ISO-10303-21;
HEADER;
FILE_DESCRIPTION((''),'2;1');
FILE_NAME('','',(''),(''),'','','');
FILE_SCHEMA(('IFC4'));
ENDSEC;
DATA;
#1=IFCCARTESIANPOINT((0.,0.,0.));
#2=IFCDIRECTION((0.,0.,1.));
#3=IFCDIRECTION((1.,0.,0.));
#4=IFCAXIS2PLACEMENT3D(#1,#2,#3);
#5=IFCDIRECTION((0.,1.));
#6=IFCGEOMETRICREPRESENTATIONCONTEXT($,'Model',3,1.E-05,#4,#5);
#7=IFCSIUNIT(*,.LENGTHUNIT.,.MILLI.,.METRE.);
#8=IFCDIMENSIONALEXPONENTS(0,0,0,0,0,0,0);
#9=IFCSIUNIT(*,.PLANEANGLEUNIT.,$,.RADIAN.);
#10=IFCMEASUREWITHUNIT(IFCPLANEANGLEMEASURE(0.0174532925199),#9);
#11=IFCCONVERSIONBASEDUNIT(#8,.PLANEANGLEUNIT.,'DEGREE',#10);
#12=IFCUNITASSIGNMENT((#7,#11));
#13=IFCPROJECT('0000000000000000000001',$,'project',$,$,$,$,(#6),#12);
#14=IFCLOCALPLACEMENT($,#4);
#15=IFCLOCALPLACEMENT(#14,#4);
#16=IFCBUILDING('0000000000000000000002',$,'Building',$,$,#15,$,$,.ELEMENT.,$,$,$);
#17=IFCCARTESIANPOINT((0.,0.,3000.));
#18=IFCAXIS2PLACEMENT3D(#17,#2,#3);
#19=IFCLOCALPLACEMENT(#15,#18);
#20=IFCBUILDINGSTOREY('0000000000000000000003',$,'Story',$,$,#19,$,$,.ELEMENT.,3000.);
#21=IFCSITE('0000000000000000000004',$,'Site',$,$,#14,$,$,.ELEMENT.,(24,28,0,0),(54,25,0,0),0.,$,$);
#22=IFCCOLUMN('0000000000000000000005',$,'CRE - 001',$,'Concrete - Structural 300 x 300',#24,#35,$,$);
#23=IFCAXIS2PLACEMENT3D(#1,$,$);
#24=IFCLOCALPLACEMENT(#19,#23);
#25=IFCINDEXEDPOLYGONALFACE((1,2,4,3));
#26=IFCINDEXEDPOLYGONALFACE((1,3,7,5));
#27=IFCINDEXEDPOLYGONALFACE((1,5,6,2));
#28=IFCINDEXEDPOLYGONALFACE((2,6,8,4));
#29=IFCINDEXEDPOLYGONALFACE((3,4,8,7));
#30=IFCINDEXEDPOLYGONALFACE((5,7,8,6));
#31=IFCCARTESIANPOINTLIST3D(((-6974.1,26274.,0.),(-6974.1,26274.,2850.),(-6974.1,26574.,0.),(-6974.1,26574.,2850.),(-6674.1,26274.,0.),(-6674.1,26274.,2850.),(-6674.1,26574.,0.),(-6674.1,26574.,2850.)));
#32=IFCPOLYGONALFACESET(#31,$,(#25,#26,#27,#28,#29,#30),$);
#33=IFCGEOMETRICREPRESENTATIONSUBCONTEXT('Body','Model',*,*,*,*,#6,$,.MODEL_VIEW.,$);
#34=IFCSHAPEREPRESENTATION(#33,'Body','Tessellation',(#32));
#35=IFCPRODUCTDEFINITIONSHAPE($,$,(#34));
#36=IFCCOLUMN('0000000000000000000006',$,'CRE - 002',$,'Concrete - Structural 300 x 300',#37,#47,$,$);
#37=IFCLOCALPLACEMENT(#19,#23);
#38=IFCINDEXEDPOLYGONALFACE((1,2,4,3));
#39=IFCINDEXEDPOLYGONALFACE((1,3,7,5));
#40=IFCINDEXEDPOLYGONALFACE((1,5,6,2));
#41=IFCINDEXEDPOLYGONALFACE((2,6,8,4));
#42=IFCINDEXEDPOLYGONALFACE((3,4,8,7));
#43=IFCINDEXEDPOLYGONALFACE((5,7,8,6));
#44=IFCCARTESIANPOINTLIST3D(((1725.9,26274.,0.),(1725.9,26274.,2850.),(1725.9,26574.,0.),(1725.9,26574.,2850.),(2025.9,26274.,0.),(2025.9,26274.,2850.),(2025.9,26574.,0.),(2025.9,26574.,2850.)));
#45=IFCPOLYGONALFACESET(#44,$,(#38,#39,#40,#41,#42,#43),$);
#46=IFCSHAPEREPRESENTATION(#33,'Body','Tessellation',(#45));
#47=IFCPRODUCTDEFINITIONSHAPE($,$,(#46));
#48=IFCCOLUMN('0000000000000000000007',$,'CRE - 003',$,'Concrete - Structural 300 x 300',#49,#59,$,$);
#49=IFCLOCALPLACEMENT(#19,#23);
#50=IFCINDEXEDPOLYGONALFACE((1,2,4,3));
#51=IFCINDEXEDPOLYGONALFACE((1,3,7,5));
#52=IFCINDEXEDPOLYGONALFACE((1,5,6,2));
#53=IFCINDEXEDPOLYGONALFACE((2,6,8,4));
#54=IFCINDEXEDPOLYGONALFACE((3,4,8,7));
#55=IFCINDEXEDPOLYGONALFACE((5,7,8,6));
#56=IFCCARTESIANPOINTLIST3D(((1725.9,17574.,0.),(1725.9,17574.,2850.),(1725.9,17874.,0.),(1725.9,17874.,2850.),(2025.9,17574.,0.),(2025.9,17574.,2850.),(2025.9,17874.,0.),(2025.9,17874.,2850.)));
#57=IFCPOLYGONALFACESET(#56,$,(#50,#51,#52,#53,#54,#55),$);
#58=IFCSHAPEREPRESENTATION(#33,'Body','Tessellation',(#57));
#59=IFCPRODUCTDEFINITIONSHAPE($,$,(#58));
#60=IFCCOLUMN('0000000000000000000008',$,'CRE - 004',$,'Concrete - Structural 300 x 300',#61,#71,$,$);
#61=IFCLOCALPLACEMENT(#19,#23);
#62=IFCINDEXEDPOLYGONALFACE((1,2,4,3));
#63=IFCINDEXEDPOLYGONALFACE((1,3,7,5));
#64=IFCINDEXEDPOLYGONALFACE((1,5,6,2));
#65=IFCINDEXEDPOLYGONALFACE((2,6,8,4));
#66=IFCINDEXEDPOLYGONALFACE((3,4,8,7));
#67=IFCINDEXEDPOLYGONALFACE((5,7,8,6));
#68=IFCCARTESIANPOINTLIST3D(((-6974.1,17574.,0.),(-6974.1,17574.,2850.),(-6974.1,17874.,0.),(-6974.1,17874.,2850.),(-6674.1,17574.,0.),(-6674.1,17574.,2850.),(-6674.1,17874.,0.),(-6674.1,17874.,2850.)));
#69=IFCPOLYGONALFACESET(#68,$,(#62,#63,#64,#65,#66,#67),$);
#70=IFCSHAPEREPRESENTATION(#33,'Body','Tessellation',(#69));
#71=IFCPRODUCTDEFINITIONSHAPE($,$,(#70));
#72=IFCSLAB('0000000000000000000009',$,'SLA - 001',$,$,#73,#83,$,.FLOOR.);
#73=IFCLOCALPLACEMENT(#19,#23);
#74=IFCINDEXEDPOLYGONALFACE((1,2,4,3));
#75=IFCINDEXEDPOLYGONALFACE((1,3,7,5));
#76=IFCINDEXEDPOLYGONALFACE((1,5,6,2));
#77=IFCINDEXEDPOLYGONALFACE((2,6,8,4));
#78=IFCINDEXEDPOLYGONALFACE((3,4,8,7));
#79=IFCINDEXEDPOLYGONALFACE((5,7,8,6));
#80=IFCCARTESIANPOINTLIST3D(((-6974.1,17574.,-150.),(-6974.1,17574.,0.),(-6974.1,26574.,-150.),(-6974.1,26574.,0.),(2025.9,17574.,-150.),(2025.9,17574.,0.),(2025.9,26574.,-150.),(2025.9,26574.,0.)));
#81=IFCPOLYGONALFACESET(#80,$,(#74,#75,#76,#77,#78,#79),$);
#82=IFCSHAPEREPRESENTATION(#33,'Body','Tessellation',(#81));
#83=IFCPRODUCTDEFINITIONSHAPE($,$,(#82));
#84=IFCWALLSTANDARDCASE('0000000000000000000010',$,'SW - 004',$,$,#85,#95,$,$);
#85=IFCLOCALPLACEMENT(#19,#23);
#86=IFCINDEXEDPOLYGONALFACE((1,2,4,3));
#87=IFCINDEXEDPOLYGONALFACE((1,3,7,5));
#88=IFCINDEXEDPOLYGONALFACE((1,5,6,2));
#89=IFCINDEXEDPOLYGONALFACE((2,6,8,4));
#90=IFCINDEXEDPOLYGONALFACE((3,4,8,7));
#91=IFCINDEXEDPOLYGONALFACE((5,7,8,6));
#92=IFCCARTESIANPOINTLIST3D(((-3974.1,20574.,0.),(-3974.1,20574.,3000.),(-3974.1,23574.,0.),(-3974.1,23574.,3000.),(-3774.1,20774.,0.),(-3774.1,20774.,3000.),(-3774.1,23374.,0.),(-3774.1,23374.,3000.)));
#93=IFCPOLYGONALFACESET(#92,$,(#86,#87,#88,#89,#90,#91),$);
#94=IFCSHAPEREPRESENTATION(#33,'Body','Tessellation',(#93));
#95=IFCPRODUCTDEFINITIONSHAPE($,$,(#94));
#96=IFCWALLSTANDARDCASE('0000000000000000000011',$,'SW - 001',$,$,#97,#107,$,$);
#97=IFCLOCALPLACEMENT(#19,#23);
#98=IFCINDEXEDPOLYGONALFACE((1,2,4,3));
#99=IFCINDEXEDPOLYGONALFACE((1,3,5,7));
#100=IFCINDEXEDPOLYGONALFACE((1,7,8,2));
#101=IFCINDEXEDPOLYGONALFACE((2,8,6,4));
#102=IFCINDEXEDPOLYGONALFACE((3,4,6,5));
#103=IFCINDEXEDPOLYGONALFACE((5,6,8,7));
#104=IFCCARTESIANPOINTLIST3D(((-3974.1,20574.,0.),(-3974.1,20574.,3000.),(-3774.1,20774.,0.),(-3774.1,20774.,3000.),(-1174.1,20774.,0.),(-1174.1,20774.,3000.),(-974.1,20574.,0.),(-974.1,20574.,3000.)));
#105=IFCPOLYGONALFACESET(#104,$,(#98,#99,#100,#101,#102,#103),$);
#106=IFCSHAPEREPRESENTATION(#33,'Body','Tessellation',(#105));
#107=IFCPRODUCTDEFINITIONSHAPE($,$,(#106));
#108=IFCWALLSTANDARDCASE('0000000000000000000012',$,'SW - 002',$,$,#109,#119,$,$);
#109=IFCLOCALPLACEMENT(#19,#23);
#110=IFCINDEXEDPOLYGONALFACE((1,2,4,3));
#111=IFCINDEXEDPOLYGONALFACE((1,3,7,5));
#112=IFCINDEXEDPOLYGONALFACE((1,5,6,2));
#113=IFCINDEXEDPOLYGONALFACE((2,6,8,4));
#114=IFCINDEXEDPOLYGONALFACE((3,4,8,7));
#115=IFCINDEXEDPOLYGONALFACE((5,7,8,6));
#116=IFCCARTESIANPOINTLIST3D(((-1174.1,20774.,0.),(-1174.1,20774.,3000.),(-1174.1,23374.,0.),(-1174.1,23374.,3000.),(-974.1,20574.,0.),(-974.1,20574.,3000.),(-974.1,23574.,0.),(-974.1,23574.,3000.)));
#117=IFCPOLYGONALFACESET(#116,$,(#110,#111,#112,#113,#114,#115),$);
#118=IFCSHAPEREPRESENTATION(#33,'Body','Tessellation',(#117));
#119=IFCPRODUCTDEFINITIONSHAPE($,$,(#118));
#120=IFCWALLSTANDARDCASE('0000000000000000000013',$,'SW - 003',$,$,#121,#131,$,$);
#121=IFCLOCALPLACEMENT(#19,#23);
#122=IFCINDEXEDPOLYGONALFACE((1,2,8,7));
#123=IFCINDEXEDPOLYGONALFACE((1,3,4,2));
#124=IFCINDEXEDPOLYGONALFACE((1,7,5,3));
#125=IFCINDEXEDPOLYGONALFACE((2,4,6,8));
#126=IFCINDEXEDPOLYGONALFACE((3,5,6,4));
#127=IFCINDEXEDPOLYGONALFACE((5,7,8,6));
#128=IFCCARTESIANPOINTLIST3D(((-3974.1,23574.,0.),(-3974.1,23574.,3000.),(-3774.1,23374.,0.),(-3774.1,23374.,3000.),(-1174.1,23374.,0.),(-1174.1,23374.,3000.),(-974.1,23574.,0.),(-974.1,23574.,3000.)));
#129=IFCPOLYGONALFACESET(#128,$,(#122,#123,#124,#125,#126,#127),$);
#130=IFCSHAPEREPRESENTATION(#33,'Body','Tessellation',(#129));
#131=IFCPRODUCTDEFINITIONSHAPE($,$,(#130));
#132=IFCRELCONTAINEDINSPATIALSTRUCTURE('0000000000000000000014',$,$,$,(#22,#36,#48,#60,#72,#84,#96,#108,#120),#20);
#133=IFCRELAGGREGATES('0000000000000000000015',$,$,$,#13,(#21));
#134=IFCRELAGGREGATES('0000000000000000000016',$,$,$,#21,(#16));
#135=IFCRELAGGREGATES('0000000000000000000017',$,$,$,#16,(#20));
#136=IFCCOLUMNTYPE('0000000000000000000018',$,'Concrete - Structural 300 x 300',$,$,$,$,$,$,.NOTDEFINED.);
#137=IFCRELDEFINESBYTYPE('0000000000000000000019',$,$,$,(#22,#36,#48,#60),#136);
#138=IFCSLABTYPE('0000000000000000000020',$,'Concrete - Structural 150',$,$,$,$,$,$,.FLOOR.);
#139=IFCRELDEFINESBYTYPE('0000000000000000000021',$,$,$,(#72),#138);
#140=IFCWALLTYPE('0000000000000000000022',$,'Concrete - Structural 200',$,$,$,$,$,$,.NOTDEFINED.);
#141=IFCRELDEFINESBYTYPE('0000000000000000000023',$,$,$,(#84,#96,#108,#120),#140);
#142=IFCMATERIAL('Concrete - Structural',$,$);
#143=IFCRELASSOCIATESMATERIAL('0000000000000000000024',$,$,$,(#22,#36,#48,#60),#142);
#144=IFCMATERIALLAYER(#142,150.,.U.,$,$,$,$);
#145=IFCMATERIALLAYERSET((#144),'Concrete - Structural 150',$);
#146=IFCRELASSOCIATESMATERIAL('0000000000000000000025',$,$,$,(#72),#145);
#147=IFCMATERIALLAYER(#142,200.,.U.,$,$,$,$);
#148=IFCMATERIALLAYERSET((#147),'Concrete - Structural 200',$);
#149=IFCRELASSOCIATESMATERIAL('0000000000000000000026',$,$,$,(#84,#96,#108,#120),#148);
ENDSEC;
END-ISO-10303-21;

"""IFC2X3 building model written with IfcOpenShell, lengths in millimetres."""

from ifc_helpers import new_model, entity, si_unit, converted_unit, direction, frame, origin_with_axes, origin_2d_with_axis, place, context, subcontext, project, spatial, polyline, rectangle, outline, extrude, material, layer, layer_set, layer_usage, type_object, element, save


model = new_model("IFC2X3")

# Units and contexts
model_context = context("Model", 3, precision=1e-05, world=origin_with_axes(), true_north=direction((0.0, 1.0)))
body_context = subcontext(model_context, "Body", "Model", "MODEL_VIEW")
ifc_project = project(units=[si_unit("LENGTHUNIT", "METRE", prefix="MILLI"), converted_unit("PLANEANGLEUNIT", "DEGREE", entity("IfcPlaneAngleMeasure", 0.0174532925199), si_unit("PLANEANGLEUNIT", "RADIAN"), dimensions=[0, 0, 0, 0, 0, 0, 0])], contexts=[model_context])

# Site, building, storey
site_placement = place(None, origin_with_axes())
site = spatial("IfcSite", under=ifc_project, at=site_placement, Name="Site", CompositionType="ELEMENT", RefLatitude=(24, 28, 0, 0), RefLongitude=(54, 25, 0, 0), RefElevation=0.0)
building_placement = place(site_placement, origin_with_axes())
building = spatial("IfcBuilding", under=site, at=building_placement, Name="Building", CompositionType="ELEMENT")
storey_placement = place(building_placement, frame((0.0, 0.0, 3000.0), z_axis=(0.0, 0.0, 1.0), x_axis=(1.0, 0.0, 0.0)))
storey = spatial("IfcBuildingStorey", under=building, at=storey_placement, Name="Story", CompositionType="ELEMENT", Elevation=3000.0)

# Columns
ifc_material = material(Name="Concrete - Structural")
column_type = type_object("IfcColumnType", Name="Concrete - Structural 300 x 300", PredefinedType="NOTDEFINED")
for number, where, z_axis, x_axis, name in (
    (1, (-6824.1, 26424.0, 0.0), (0.0, 0.0, 1.0), (1.0, 0.0, 0.0), "CRE - 001"),
    (2, (1875.9, 26424.0, 0.0), (0.0, 0.0, 1.0), (1.0, 0.0, 0.0), "CRE - 002"),
    (3, (1875.9, 17724.0, 0.0), (0.0, 0.0, 1.0), (1.0, 0.0, 0.0), "CRE - 003"),
    (4, (-6824.1, 17724.0, 0.0), (0.0, 0.0, 1.0), (1.0, 0.0, 0.0), "CRE - 004"),
):
    element("IfcColumn", number, at=place(storey_placement, frame(where, z_axis=z_axis, x_axis=x_axis)), inside=storey, type_object=column_type, material=ifc_material, Name=name, ObjectType="Concrete - Structural 300 x 300", context=body_context, shape_type="SweptSolid", body=[
        extrude(rectangle(XDim=300.0, YDim=300.0, at=origin_2d_with_axis()), origin_with_axes(), (0.0, 0.0, 1.0), 2850.0),
    ])

# Slab
ifc_layer_1 = layer(ifc_material, 150.0, ventilated="UNKNOWN")
ifc_layer_set_1 = layer_set([ifc_layer_1], Name="Concrete - Structural 150")
ifc_layer_usage_1 = layer_usage(ifc_layer_set_1, "AXIS3", "NEGATIVE", 150.0)
slab_type = type_object("IfcSlabType", Name="Concrete - Structural 150", PredefinedType="FLOOR")
slab_placement = place(storey_placement, frame((-6974.1, 26574.0, 0.0), z_axis=(0.0, 0.0, 1.0), x_axis=(1.0, 0.0, 0.0)))
element("IfcSlab", 5, at=slab_placement, inside=storey, type_object=slab_type, material=ifc_layer_usage_1, Name="SLA - 001", PredefinedType="FLOOR", context=body_context, shape_type="SweptSolid", body=[
    extrude(outline(polyline([(0.0, 0.0), (0.0, -9000.0), (9000.0, -9000.0), (9000.0, 0.0), (0.0, 0.0)])), frame((0.0, 0.0, -150.0), z_axis=(0.0, 0.0, 1.0), x_axis=(1.0, 0.0, 0.0)), (0.0, 0.0, 1.0), 150.0),
])

# Walls
ifc_layer_2 = layer(ifc_material, 200.0, ventilated="UNKNOWN")
ifc_layer_set_2 = layer_set([ifc_layer_2], Name="Concrete - Structural 200")
ifc_layer_usage_2 = layer_usage(ifc_layer_set_2, "AXIS2", "POSITIVE", 0.0)
wall_type = type_object("IfcWallType", Name="Concrete - Structural 200", PredefinedType="NOTDEFINED")
wall_1_placement = place(storey_placement, frame((-3974.1, 23574.0, 0.0), z_axis=(0.0, 0.0, 1.0), x_axis=(0.0, -1.0, 0.0)))
element("IfcWallStandardCase", 6, at=wall_1_placement, inside=storey, type_object=wall_type, material=ifc_layer_usage_2, Name="SW - 004", context=body_context, shape_type="SweptSolid", body=[
    extrude(outline(polyline([(0.0, 0.0), (3000.0, 0.0), (2800.0, 200.0), (200.0, 200.0), (0.0, 0.0)])), origin_with_axes(), (0.0, 0.0, 1.0), 3000.0),
])
ifc_layer_usage_3 = layer_usage(ifc_layer_set_2, "AXIS2", "POSITIVE", 0.0)
wall_2_placement = place(storey_placement, frame((-3974.1, 20574.0, 0.0), z_axis=(0.0, 0.0, 1.0), x_axis=(1.0, 0.0, 0.0)))
element("IfcWallStandardCase", 7, at=wall_2_placement, inside=storey, type_object=wall_type, material=ifc_layer_usage_3, Name="SW - 001", context=body_context, shape_type="SweptSolid", body=[
    extrude(outline(polyline([(0.0, 0.0), (3000.0, 0.0), (2800.0, 200.0), (200.0, 200.0), (0.0, 0.0)])), origin_with_axes(), (0.0, 0.0, 1.0), 3000.0),
])
ifc_layer_usage_4 = layer_usage(ifc_layer_set_2, "AXIS2", "POSITIVE", 0.0)
wall_3_placement = place(storey_placement, frame((-974.1, 20574.0, 0.0), z_axis=(0.0, 0.0, 1.0), x_axis=(0.0, 1.0, 0.0)))
element("IfcWallStandardCase", 8, at=wall_3_placement, inside=storey, type_object=wall_type, material=ifc_layer_usage_4, Name="SW - 002", context=body_context, shape_type="SweptSolid", body=[
    extrude(outline(polyline([(0.0, 0.0), (3000.0, 0.0), (2800.0, 200.0), (200.0, 200.0), (0.0, 0.0)])), origin_with_axes(), (0.0, 0.0, 1.0), 3000.0),
])
ifc_layer_usage_5 = layer_usage(ifc_layer_set_2, "AXIS2", "POSITIVE", 0.0)
wall_4_placement = place(storey_placement, frame((-974.1, 23574.0, 0.0), z_axis=(0.0, 0.0, 1.0), x_axis=(-1.0, 0.0, 0.0)))
element("IfcWallStandardCase", 9, at=wall_4_placement, inside=storey, type_object=wall_type, material=ifc_layer_usage_5, Name="SW - 003", context=body_context, shape_type="SweptSolid", body=[
    extrude(outline(polyline([(0.0, 0.0), (3000.0, 0.0), (2800.0, 200.0), (200.0, 200.0), (0.0, 0.0)])), origin_with_axes(), (0.0, 0.0, 1.0), 3000.0),
])

save(model, "model.ifc")
